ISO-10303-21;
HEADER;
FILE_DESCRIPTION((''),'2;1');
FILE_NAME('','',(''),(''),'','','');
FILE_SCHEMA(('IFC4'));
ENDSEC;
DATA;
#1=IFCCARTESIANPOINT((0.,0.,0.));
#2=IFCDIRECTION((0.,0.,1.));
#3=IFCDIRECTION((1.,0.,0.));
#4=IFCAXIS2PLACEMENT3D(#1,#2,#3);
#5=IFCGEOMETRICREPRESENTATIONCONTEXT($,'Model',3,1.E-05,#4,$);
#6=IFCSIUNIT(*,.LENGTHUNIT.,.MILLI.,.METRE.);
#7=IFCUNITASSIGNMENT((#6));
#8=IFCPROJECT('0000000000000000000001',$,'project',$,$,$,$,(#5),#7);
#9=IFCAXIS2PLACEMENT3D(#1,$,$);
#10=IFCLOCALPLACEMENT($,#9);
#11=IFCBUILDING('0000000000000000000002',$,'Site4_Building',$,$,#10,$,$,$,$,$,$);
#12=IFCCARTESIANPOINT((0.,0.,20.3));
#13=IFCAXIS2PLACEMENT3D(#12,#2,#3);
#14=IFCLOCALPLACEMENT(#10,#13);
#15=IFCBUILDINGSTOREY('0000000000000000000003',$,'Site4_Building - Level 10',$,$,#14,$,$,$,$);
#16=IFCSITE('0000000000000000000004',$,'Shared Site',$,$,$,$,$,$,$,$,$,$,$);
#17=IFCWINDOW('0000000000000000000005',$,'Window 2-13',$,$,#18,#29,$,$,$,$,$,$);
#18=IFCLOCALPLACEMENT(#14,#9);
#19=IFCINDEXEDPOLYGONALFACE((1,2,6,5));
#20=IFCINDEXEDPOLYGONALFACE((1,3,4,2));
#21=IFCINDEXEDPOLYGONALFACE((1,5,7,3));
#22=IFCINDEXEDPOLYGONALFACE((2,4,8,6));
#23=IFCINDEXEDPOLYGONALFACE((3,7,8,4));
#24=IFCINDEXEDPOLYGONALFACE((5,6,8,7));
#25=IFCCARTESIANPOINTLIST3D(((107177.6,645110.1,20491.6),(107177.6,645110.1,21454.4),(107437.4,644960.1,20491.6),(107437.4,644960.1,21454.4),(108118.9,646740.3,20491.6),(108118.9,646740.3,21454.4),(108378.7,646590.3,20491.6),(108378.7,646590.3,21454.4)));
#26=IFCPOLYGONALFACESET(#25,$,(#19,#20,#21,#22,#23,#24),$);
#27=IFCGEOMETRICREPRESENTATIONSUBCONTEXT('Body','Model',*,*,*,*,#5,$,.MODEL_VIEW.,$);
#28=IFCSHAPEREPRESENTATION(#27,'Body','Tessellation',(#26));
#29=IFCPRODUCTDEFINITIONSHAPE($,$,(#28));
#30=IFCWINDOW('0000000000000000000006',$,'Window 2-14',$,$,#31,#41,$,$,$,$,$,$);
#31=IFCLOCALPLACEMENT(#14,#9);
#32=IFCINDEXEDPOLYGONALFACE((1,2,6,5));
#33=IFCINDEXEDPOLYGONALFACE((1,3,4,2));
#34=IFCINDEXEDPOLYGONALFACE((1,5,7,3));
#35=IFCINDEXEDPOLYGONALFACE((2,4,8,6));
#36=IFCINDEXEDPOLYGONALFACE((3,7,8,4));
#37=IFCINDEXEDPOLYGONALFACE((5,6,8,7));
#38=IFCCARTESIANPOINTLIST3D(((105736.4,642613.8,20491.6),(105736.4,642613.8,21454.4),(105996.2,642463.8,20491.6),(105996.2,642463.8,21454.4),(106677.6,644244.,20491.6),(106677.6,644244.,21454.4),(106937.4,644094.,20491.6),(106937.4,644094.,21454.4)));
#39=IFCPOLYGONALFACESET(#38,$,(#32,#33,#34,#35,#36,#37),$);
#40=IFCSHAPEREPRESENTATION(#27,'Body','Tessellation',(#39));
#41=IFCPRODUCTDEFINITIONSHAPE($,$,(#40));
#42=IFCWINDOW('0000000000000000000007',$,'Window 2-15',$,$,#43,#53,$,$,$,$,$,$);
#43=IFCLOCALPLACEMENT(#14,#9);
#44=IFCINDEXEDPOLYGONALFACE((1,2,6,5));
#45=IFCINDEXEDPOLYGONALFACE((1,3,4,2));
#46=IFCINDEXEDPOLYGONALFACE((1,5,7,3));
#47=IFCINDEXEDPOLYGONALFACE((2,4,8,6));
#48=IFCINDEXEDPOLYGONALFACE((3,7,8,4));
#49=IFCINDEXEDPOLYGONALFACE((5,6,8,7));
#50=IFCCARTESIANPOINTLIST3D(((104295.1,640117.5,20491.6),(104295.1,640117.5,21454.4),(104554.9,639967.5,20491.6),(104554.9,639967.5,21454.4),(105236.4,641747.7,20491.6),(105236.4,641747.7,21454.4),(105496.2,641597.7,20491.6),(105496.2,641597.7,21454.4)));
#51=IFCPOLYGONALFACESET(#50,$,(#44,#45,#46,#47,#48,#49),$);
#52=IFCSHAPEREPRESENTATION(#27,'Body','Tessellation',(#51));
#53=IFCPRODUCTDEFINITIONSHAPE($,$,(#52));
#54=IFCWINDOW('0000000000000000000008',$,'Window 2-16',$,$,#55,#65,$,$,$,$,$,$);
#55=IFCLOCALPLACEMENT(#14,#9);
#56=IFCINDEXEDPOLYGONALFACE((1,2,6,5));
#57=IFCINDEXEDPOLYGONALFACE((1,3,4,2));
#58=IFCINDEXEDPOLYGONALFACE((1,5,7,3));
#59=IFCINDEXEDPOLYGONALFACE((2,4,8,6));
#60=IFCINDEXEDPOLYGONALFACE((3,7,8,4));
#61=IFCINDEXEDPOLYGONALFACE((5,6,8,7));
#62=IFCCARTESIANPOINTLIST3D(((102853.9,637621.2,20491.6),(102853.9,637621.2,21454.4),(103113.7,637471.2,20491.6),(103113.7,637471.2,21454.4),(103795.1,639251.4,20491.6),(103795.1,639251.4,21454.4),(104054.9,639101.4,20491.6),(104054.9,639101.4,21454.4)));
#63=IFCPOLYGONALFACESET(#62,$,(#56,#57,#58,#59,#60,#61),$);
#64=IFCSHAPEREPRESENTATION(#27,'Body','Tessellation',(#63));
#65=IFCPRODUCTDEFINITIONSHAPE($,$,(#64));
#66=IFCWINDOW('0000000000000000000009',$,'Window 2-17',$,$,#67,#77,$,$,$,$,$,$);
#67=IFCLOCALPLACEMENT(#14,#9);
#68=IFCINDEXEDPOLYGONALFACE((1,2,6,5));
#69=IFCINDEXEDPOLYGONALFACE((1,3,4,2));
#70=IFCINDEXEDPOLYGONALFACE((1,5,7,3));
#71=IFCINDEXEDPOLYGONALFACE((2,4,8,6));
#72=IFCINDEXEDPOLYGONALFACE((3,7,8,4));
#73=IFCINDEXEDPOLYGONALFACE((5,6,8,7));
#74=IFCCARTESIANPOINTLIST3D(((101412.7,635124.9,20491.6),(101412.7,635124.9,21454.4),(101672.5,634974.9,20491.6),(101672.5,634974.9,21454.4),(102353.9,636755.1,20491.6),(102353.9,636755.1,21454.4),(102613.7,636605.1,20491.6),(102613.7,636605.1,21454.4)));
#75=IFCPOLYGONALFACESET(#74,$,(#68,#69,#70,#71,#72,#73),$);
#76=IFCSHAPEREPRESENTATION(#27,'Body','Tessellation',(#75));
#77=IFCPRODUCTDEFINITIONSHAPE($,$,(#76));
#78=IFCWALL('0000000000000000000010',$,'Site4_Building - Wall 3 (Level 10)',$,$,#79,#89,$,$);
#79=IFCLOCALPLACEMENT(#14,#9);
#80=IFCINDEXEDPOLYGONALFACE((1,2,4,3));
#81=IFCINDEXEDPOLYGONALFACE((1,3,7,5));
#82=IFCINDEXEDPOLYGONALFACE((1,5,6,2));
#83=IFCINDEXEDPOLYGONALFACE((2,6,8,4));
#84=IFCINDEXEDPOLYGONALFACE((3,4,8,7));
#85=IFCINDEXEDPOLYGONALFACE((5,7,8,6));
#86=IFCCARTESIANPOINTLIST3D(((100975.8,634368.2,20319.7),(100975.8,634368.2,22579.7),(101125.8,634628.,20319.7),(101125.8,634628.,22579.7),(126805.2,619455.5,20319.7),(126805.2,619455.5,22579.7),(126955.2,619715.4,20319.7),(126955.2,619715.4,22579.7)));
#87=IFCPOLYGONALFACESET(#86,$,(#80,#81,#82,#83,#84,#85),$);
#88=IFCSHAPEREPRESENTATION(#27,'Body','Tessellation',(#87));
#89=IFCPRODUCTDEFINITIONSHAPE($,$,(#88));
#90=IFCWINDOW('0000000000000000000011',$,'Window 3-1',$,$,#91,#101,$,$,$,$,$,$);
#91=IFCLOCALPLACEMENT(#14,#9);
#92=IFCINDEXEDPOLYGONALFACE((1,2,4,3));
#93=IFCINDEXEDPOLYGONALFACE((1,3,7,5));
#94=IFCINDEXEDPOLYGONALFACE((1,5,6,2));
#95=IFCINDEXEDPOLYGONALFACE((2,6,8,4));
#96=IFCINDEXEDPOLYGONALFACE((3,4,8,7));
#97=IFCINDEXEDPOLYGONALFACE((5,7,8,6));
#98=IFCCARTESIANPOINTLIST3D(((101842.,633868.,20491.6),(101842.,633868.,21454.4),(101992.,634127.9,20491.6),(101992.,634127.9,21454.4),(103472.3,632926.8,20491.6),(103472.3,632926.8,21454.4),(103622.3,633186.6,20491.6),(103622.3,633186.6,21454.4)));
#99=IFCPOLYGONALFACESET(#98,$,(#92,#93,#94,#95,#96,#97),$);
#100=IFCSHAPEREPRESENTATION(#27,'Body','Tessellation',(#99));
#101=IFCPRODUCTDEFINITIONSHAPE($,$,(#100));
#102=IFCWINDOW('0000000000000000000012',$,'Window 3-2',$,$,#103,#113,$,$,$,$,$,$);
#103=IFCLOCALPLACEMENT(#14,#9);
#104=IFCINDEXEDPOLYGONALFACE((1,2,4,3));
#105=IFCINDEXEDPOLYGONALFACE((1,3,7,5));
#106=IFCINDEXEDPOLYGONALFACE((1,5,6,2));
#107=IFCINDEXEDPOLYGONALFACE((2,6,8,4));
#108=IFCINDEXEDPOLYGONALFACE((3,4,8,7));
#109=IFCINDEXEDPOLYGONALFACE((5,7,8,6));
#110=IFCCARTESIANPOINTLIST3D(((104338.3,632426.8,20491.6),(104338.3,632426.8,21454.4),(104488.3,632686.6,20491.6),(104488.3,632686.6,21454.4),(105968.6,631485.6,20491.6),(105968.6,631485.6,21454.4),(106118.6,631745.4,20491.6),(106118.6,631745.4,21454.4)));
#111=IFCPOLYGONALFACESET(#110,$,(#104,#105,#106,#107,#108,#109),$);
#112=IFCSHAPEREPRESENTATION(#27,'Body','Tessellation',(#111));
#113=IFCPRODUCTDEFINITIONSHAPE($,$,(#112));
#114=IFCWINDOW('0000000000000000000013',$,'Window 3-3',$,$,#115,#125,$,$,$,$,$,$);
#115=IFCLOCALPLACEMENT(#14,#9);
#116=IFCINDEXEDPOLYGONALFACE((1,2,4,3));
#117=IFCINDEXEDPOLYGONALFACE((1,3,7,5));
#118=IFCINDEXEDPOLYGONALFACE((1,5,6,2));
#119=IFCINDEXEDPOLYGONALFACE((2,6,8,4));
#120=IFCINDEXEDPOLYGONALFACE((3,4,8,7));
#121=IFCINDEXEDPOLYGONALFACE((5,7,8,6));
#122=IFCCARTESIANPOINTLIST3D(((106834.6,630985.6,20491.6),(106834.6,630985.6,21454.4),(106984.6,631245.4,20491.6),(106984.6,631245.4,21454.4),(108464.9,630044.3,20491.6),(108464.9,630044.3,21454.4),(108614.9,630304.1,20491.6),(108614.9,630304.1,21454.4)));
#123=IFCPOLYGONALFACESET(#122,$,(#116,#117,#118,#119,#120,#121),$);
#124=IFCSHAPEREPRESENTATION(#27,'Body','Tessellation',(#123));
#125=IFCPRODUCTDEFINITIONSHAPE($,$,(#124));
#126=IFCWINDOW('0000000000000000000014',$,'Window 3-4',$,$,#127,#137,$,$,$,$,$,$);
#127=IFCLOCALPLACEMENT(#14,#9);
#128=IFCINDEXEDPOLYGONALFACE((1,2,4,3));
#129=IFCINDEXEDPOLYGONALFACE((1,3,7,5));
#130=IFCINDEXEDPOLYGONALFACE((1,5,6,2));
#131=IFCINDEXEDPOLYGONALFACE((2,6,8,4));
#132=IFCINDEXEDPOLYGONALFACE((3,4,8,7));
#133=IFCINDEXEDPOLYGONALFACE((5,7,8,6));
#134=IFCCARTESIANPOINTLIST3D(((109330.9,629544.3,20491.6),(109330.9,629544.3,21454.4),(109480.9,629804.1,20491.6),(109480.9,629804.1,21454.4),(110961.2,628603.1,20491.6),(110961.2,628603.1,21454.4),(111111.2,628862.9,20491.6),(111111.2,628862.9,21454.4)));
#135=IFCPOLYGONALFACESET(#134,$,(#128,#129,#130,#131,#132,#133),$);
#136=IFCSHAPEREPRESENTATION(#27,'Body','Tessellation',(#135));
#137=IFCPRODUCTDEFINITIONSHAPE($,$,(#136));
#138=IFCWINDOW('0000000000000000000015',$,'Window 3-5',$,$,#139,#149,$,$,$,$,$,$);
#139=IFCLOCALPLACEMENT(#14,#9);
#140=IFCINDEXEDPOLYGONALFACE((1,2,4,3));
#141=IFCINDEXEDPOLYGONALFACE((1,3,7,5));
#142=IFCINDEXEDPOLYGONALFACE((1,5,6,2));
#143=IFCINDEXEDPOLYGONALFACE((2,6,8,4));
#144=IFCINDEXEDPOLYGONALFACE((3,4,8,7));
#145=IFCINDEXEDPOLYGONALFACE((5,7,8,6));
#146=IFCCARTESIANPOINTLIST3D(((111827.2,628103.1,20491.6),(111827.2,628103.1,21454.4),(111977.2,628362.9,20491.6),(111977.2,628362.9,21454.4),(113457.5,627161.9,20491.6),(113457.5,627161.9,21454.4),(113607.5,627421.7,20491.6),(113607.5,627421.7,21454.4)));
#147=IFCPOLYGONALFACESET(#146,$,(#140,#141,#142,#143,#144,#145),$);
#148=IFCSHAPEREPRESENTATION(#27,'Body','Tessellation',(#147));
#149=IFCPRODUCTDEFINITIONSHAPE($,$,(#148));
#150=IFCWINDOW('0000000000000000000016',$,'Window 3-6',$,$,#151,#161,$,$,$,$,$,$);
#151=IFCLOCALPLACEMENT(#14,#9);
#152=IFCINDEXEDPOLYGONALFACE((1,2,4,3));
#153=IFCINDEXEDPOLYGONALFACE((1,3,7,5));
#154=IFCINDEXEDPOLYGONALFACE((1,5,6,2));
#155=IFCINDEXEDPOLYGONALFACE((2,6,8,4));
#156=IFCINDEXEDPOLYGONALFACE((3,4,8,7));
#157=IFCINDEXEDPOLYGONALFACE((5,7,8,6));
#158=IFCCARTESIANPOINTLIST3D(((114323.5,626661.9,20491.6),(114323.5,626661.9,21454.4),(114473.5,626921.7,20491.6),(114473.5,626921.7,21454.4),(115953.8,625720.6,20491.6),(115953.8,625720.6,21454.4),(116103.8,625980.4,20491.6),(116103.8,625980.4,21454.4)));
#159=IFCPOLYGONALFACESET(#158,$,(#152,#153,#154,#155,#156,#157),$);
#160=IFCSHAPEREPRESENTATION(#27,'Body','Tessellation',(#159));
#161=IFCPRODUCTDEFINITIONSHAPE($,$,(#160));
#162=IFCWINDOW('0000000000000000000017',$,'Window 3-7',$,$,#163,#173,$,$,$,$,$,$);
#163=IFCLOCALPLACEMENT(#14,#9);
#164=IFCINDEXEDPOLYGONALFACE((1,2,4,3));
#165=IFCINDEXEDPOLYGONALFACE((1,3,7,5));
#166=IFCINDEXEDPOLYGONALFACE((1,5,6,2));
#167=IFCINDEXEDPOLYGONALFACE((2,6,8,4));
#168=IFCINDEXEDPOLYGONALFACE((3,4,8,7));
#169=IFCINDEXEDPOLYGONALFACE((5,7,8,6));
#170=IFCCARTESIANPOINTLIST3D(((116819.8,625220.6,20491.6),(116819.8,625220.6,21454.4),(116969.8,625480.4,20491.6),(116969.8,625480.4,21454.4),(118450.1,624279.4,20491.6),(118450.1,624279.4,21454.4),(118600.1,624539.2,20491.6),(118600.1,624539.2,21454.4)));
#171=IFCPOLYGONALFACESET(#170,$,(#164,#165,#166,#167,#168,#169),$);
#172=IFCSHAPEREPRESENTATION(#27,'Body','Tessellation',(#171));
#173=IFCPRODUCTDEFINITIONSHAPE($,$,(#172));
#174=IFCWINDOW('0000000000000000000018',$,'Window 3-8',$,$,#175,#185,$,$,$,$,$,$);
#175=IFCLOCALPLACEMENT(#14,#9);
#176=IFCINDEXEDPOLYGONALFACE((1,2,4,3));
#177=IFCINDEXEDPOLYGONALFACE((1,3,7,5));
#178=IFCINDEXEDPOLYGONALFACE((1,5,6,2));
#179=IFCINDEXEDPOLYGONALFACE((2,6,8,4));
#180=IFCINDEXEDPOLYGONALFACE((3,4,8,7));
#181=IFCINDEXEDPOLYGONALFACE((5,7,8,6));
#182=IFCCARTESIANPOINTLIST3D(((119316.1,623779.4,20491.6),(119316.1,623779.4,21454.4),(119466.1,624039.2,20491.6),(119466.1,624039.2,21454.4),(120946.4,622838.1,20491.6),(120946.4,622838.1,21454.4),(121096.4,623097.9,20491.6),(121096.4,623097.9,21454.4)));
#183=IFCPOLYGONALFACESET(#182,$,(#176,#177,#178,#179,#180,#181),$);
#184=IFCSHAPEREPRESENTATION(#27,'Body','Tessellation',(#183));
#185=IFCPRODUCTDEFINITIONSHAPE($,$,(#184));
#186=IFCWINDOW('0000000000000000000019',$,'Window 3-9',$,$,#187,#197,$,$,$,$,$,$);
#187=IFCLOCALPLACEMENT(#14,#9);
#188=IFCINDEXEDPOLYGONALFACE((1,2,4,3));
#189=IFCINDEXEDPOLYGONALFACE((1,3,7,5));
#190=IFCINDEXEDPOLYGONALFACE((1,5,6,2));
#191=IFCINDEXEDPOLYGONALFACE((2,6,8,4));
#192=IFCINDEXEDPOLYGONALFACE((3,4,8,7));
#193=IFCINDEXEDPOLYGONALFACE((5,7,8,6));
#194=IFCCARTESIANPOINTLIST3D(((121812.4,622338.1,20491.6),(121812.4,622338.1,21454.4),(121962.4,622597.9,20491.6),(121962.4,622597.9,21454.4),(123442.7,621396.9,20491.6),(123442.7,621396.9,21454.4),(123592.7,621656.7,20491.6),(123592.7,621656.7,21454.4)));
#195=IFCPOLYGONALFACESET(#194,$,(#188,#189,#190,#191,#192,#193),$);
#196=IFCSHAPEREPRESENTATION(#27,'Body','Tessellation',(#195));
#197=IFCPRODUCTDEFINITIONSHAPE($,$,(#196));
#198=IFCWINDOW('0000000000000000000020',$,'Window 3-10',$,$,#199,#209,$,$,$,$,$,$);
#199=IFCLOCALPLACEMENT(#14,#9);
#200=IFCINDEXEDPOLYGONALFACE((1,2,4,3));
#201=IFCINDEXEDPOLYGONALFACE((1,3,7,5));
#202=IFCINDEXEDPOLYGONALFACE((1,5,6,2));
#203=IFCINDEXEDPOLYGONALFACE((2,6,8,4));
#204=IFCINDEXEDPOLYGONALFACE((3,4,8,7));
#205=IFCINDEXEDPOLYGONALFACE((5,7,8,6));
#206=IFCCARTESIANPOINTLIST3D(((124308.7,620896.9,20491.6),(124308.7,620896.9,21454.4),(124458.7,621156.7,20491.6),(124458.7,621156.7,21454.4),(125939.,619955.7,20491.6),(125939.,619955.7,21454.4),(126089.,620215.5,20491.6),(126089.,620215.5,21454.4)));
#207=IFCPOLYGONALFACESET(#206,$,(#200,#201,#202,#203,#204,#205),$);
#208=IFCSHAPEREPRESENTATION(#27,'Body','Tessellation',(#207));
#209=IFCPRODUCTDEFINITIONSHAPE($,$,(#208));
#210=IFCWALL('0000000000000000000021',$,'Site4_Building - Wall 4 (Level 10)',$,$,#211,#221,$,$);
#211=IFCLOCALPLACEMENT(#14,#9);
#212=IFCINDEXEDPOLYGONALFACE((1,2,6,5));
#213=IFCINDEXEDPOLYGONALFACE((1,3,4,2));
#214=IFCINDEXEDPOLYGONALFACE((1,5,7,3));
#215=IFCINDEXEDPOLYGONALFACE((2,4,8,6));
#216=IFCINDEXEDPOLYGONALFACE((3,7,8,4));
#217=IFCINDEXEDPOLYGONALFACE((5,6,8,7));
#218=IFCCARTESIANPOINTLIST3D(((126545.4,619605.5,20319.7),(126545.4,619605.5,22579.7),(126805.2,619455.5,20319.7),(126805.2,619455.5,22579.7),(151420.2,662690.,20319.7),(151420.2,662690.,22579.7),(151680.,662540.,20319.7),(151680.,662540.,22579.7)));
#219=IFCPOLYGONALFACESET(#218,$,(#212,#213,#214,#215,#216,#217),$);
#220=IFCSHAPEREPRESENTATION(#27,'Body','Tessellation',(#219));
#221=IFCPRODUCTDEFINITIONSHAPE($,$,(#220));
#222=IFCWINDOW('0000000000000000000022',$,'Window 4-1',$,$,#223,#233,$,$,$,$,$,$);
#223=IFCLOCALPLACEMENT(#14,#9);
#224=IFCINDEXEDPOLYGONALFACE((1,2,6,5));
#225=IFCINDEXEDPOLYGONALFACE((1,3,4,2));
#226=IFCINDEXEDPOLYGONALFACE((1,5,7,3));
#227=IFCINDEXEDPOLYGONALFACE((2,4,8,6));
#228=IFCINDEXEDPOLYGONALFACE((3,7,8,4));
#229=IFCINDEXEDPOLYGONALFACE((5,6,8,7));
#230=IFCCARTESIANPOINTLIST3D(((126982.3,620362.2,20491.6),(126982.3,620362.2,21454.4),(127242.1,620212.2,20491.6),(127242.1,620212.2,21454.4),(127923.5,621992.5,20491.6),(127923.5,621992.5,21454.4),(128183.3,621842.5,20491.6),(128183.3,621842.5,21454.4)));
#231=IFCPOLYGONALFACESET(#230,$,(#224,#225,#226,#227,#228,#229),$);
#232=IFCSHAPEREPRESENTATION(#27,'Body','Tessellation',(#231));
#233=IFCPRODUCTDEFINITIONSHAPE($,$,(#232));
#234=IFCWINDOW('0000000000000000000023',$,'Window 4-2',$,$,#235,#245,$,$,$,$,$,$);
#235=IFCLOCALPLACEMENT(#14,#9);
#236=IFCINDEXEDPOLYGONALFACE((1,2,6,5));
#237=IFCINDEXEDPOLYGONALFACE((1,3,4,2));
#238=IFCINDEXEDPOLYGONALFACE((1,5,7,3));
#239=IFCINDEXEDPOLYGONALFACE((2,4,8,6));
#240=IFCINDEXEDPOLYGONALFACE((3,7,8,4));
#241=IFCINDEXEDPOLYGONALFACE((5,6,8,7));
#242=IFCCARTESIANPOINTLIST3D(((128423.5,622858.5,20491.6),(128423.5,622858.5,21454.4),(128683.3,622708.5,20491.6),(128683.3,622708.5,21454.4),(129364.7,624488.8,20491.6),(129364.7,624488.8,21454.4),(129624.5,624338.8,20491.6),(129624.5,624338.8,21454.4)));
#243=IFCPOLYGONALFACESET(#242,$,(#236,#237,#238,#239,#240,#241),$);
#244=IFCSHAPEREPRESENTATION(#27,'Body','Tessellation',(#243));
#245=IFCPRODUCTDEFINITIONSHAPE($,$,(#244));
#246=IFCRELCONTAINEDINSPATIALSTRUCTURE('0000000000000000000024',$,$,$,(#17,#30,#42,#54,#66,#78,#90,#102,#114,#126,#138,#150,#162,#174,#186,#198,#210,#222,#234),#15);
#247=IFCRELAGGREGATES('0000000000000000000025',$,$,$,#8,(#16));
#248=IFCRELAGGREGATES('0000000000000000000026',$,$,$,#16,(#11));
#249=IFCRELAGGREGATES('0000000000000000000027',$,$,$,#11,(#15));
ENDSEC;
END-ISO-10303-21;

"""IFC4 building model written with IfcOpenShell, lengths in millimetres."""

from ifc_helpers import new_model, si_unit, frame, origin, origin_with_axes, place, context, subcontext, project, spatial, indexed_curve, outline, extrude, element, save


model = new_model("IFC4")

# Units and contexts
model_context = context("Model", 3, precision=1e-05, world=origin_with_axes())
body_context = subcontext(model_context, "Body", "Model", "MODEL_VIEW")
ifc_project = project(units=[si_unit("LENGTHUNIT", "METRE", prefix="MILLI")], contexts=[model_context])

# Site, building, storey
site = spatial("IfcSite", under=ifc_project, Name="Shared Site")
building_placement = place(None, origin())
building = spatial("IfcBuilding", under=site, at=building_placement, Name="Site4_Building")
storey_placement = place(building_placement, frame((0.0, 0.0, 20.3), z_axis=(0.0, 0.0, 1.0), x_axis=(1.0, 0.0, 0.0)))
storey = spatial("IfcBuildingStorey", under=building, at=storey_placement, Name="Site4_Building - Level 10")

# Windows
for number, where, z_axis, x_axis, name in (
    (1, (108118.9, 646740.3, 20491.6), (0.0, 0.0, 1.0), (-0.5, -0.866025, 0.0), "Window 2-13"),
    (2, (106677.6, 644244.0, 20491.6), (0.0, 0.0, 1.0), (-0.5, -0.866025, 0.0), "Window 2-14"),
    (3, (105236.4, 641747.7, 20491.6), (0.0, 0.0, 1.0), (-0.5, -0.866025, 0.0), "Window 2-15"),
    (4, (103795.1, 639251.4, 20491.6), (0.0, 0.0, 1.0), (-0.5, -0.866025, 0.0), "Window 2-16"),
    (5, (102353.9, 636755.1, 20491.6), (0.0, 0.0, 1.0), (-0.5, -0.866025, 0.0), "Window 2-17"),
):
    element("IfcWindow", number, at=place(storey_placement, frame(where, z_axis=z_axis, x_axis=x_axis)), inside=storey, Name=name, context=body_context, shape_type="SweptSolid", body=[
        extrude(outline(indexed_curve([(0.0, 0.0), (0.0, 300.0), (1882.5, 300.0), (1882.5, 0.0), (0.0, 0.0)], self_intersect=False)), origin_with_axes(), (0.0, 0.0, 1.0), 962.8),
    ])

# Wall
wall_1_placement = place(storey_placement, frame((100975.8, 634368.2, 20319.7), z_axis=(0.0, 0.0, 1.0), x_axis=(0.866025, -0.5, 0.0)))
element("IfcWall", 6, at=wall_1_placement, inside=storey, Name="Site4_Building - Wall 3 (Level 10)", context=body_context, shape_type="SweptSolid", body=[
    extrude(outline(indexed_curve([(0.0, 0.0), (0.0, 300.0), (29825.2, 300.0), (29825.2, 0.0), (0.0, 0.0)], self_intersect=False)), origin_with_axes(), (0.0, 0.0, 1.0), 2260.0),
])

# Windows
for number, where, z_axis, x_axis, name in (
    (7, (101842.0, 633868.0, 20491.6), (0.0, 0.0, 1.0), (0.866025, -0.5, 0.0), "Window 3-1"),
    (8, (104338.3, 632426.8, 20491.6), (0.0, 0.0, 1.0), (0.866025, -0.5, 0.0), "Window 3-2"),
    (9, (106834.6, 630985.6, 20491.6), (0.0, 0.0, 1.0), (0.866025, -0.5, 0.0), "Window 3-3"),
    (10, (109330.9, 629544.3, 20491.6), (0.0, 0.0, 1.0), (0.866025, -0.5, 0.0), "Window 3-4"),
    (11, (111827.2, 628103.1, 20491.6), (0.0, 0.0, 1.0), (0.866025, -0.5, 0.0), "Window 3-5"),
    (12, (114323.5, 626661.9, 20491.6), (0.0, 0.0, 1.0), (0.866025, -0.5, 0.0), "Window 3-6"),
    (13, (116819.8, 625220.6, 20491.6), (0.0, 0.0, 1.0), (0.866025, -0.5, 0.0), "Window 3-7"),
    (14, (119316.1, 623779.4, 20491.6), (0.0, 0.0, 1.0), (0.866025, -0.5, 0.0), "Window 3-8"),
    (15, (121812.4, 622338.1, 20491.6), (0.0, 0.0, 1.0), (0.866025, -0.5, 0.0), "Window 3-9"),
    (16, (124308.7, 620896.9, 20491.6), (0.0, 0.0, 1.0), (0.866025, -0.5, 0.0), "Window 3-10"),
):
    element("IfcWindow", number, at=place(storey_placement, frame(where, z_axis=z_axis, x_axis=x_axis)), inside=storey, Name=name, context=body_context, shape_type="SweptSolid", body=[
        extrude(outline(indexed_curve([(0.0, 0.0), (0.0, 300.0), (1882.5, 300.0), (1882.5, 0.0), (0.0, 0.0)], self_intersect=False)), origin_with_axes(), (0.0, 0.0, 1.0), 962.8),
    ])

# Wall
wall_2_placement = place(storey_placement, frame((126805.2, 619455.5, 20319.7), z_axis=(0.0, 0.0, 1.0), x_axis=(0.5, 0.866025, 0.0)))
element("IfcWall", 17, at=wall_2_placement, inside=storey, Name="Site4_Building - Wall 4 (Level 10)", context=body_context, shape_type="SweptSolid", body=[
    extrude(outline(indexed_curve([(0.0, 0.0), (0.0, 300.0), (49749.6, 300.0), (49749.6, 0.0), (0.0, 0.0)], self_intersect=False)), origin_with_axes(), (0.0, 0.0, 1.0), 2260.0),
])

# Windows
for number, where, z_axis, x_axis, name in (
    (18, (127242.1, 620212.2, 20491.6), (0.0, 0.0, 1.0), (0.5, 0.866025, 0.0), "Window 4-1"),
    (19, (128683.3, 622708.5, 20491.6), (0.0, 0.0, 1.0), (0.5, 0.866025, 0.0), "Window 4-2"),
):
    element("IfcWindow", number, at=place(storey_placement, frame(where, z_axis=z_axis, x_axis=x_axis)), inside=storey, Name=name, context=body_context, shape_type="SweptSolid", body=[
        extrude(outline(indexed_curve([(0.0, 0.0), (0.0, 300.0), (1882.5, 300.0), (1882.5, 0.0), (0.0, 0.0)], self_intersect=False)), origin_with_axes(), (0.0, 0.0, 1.0), 962.8),
    ])

save(model, "model.ifc")
